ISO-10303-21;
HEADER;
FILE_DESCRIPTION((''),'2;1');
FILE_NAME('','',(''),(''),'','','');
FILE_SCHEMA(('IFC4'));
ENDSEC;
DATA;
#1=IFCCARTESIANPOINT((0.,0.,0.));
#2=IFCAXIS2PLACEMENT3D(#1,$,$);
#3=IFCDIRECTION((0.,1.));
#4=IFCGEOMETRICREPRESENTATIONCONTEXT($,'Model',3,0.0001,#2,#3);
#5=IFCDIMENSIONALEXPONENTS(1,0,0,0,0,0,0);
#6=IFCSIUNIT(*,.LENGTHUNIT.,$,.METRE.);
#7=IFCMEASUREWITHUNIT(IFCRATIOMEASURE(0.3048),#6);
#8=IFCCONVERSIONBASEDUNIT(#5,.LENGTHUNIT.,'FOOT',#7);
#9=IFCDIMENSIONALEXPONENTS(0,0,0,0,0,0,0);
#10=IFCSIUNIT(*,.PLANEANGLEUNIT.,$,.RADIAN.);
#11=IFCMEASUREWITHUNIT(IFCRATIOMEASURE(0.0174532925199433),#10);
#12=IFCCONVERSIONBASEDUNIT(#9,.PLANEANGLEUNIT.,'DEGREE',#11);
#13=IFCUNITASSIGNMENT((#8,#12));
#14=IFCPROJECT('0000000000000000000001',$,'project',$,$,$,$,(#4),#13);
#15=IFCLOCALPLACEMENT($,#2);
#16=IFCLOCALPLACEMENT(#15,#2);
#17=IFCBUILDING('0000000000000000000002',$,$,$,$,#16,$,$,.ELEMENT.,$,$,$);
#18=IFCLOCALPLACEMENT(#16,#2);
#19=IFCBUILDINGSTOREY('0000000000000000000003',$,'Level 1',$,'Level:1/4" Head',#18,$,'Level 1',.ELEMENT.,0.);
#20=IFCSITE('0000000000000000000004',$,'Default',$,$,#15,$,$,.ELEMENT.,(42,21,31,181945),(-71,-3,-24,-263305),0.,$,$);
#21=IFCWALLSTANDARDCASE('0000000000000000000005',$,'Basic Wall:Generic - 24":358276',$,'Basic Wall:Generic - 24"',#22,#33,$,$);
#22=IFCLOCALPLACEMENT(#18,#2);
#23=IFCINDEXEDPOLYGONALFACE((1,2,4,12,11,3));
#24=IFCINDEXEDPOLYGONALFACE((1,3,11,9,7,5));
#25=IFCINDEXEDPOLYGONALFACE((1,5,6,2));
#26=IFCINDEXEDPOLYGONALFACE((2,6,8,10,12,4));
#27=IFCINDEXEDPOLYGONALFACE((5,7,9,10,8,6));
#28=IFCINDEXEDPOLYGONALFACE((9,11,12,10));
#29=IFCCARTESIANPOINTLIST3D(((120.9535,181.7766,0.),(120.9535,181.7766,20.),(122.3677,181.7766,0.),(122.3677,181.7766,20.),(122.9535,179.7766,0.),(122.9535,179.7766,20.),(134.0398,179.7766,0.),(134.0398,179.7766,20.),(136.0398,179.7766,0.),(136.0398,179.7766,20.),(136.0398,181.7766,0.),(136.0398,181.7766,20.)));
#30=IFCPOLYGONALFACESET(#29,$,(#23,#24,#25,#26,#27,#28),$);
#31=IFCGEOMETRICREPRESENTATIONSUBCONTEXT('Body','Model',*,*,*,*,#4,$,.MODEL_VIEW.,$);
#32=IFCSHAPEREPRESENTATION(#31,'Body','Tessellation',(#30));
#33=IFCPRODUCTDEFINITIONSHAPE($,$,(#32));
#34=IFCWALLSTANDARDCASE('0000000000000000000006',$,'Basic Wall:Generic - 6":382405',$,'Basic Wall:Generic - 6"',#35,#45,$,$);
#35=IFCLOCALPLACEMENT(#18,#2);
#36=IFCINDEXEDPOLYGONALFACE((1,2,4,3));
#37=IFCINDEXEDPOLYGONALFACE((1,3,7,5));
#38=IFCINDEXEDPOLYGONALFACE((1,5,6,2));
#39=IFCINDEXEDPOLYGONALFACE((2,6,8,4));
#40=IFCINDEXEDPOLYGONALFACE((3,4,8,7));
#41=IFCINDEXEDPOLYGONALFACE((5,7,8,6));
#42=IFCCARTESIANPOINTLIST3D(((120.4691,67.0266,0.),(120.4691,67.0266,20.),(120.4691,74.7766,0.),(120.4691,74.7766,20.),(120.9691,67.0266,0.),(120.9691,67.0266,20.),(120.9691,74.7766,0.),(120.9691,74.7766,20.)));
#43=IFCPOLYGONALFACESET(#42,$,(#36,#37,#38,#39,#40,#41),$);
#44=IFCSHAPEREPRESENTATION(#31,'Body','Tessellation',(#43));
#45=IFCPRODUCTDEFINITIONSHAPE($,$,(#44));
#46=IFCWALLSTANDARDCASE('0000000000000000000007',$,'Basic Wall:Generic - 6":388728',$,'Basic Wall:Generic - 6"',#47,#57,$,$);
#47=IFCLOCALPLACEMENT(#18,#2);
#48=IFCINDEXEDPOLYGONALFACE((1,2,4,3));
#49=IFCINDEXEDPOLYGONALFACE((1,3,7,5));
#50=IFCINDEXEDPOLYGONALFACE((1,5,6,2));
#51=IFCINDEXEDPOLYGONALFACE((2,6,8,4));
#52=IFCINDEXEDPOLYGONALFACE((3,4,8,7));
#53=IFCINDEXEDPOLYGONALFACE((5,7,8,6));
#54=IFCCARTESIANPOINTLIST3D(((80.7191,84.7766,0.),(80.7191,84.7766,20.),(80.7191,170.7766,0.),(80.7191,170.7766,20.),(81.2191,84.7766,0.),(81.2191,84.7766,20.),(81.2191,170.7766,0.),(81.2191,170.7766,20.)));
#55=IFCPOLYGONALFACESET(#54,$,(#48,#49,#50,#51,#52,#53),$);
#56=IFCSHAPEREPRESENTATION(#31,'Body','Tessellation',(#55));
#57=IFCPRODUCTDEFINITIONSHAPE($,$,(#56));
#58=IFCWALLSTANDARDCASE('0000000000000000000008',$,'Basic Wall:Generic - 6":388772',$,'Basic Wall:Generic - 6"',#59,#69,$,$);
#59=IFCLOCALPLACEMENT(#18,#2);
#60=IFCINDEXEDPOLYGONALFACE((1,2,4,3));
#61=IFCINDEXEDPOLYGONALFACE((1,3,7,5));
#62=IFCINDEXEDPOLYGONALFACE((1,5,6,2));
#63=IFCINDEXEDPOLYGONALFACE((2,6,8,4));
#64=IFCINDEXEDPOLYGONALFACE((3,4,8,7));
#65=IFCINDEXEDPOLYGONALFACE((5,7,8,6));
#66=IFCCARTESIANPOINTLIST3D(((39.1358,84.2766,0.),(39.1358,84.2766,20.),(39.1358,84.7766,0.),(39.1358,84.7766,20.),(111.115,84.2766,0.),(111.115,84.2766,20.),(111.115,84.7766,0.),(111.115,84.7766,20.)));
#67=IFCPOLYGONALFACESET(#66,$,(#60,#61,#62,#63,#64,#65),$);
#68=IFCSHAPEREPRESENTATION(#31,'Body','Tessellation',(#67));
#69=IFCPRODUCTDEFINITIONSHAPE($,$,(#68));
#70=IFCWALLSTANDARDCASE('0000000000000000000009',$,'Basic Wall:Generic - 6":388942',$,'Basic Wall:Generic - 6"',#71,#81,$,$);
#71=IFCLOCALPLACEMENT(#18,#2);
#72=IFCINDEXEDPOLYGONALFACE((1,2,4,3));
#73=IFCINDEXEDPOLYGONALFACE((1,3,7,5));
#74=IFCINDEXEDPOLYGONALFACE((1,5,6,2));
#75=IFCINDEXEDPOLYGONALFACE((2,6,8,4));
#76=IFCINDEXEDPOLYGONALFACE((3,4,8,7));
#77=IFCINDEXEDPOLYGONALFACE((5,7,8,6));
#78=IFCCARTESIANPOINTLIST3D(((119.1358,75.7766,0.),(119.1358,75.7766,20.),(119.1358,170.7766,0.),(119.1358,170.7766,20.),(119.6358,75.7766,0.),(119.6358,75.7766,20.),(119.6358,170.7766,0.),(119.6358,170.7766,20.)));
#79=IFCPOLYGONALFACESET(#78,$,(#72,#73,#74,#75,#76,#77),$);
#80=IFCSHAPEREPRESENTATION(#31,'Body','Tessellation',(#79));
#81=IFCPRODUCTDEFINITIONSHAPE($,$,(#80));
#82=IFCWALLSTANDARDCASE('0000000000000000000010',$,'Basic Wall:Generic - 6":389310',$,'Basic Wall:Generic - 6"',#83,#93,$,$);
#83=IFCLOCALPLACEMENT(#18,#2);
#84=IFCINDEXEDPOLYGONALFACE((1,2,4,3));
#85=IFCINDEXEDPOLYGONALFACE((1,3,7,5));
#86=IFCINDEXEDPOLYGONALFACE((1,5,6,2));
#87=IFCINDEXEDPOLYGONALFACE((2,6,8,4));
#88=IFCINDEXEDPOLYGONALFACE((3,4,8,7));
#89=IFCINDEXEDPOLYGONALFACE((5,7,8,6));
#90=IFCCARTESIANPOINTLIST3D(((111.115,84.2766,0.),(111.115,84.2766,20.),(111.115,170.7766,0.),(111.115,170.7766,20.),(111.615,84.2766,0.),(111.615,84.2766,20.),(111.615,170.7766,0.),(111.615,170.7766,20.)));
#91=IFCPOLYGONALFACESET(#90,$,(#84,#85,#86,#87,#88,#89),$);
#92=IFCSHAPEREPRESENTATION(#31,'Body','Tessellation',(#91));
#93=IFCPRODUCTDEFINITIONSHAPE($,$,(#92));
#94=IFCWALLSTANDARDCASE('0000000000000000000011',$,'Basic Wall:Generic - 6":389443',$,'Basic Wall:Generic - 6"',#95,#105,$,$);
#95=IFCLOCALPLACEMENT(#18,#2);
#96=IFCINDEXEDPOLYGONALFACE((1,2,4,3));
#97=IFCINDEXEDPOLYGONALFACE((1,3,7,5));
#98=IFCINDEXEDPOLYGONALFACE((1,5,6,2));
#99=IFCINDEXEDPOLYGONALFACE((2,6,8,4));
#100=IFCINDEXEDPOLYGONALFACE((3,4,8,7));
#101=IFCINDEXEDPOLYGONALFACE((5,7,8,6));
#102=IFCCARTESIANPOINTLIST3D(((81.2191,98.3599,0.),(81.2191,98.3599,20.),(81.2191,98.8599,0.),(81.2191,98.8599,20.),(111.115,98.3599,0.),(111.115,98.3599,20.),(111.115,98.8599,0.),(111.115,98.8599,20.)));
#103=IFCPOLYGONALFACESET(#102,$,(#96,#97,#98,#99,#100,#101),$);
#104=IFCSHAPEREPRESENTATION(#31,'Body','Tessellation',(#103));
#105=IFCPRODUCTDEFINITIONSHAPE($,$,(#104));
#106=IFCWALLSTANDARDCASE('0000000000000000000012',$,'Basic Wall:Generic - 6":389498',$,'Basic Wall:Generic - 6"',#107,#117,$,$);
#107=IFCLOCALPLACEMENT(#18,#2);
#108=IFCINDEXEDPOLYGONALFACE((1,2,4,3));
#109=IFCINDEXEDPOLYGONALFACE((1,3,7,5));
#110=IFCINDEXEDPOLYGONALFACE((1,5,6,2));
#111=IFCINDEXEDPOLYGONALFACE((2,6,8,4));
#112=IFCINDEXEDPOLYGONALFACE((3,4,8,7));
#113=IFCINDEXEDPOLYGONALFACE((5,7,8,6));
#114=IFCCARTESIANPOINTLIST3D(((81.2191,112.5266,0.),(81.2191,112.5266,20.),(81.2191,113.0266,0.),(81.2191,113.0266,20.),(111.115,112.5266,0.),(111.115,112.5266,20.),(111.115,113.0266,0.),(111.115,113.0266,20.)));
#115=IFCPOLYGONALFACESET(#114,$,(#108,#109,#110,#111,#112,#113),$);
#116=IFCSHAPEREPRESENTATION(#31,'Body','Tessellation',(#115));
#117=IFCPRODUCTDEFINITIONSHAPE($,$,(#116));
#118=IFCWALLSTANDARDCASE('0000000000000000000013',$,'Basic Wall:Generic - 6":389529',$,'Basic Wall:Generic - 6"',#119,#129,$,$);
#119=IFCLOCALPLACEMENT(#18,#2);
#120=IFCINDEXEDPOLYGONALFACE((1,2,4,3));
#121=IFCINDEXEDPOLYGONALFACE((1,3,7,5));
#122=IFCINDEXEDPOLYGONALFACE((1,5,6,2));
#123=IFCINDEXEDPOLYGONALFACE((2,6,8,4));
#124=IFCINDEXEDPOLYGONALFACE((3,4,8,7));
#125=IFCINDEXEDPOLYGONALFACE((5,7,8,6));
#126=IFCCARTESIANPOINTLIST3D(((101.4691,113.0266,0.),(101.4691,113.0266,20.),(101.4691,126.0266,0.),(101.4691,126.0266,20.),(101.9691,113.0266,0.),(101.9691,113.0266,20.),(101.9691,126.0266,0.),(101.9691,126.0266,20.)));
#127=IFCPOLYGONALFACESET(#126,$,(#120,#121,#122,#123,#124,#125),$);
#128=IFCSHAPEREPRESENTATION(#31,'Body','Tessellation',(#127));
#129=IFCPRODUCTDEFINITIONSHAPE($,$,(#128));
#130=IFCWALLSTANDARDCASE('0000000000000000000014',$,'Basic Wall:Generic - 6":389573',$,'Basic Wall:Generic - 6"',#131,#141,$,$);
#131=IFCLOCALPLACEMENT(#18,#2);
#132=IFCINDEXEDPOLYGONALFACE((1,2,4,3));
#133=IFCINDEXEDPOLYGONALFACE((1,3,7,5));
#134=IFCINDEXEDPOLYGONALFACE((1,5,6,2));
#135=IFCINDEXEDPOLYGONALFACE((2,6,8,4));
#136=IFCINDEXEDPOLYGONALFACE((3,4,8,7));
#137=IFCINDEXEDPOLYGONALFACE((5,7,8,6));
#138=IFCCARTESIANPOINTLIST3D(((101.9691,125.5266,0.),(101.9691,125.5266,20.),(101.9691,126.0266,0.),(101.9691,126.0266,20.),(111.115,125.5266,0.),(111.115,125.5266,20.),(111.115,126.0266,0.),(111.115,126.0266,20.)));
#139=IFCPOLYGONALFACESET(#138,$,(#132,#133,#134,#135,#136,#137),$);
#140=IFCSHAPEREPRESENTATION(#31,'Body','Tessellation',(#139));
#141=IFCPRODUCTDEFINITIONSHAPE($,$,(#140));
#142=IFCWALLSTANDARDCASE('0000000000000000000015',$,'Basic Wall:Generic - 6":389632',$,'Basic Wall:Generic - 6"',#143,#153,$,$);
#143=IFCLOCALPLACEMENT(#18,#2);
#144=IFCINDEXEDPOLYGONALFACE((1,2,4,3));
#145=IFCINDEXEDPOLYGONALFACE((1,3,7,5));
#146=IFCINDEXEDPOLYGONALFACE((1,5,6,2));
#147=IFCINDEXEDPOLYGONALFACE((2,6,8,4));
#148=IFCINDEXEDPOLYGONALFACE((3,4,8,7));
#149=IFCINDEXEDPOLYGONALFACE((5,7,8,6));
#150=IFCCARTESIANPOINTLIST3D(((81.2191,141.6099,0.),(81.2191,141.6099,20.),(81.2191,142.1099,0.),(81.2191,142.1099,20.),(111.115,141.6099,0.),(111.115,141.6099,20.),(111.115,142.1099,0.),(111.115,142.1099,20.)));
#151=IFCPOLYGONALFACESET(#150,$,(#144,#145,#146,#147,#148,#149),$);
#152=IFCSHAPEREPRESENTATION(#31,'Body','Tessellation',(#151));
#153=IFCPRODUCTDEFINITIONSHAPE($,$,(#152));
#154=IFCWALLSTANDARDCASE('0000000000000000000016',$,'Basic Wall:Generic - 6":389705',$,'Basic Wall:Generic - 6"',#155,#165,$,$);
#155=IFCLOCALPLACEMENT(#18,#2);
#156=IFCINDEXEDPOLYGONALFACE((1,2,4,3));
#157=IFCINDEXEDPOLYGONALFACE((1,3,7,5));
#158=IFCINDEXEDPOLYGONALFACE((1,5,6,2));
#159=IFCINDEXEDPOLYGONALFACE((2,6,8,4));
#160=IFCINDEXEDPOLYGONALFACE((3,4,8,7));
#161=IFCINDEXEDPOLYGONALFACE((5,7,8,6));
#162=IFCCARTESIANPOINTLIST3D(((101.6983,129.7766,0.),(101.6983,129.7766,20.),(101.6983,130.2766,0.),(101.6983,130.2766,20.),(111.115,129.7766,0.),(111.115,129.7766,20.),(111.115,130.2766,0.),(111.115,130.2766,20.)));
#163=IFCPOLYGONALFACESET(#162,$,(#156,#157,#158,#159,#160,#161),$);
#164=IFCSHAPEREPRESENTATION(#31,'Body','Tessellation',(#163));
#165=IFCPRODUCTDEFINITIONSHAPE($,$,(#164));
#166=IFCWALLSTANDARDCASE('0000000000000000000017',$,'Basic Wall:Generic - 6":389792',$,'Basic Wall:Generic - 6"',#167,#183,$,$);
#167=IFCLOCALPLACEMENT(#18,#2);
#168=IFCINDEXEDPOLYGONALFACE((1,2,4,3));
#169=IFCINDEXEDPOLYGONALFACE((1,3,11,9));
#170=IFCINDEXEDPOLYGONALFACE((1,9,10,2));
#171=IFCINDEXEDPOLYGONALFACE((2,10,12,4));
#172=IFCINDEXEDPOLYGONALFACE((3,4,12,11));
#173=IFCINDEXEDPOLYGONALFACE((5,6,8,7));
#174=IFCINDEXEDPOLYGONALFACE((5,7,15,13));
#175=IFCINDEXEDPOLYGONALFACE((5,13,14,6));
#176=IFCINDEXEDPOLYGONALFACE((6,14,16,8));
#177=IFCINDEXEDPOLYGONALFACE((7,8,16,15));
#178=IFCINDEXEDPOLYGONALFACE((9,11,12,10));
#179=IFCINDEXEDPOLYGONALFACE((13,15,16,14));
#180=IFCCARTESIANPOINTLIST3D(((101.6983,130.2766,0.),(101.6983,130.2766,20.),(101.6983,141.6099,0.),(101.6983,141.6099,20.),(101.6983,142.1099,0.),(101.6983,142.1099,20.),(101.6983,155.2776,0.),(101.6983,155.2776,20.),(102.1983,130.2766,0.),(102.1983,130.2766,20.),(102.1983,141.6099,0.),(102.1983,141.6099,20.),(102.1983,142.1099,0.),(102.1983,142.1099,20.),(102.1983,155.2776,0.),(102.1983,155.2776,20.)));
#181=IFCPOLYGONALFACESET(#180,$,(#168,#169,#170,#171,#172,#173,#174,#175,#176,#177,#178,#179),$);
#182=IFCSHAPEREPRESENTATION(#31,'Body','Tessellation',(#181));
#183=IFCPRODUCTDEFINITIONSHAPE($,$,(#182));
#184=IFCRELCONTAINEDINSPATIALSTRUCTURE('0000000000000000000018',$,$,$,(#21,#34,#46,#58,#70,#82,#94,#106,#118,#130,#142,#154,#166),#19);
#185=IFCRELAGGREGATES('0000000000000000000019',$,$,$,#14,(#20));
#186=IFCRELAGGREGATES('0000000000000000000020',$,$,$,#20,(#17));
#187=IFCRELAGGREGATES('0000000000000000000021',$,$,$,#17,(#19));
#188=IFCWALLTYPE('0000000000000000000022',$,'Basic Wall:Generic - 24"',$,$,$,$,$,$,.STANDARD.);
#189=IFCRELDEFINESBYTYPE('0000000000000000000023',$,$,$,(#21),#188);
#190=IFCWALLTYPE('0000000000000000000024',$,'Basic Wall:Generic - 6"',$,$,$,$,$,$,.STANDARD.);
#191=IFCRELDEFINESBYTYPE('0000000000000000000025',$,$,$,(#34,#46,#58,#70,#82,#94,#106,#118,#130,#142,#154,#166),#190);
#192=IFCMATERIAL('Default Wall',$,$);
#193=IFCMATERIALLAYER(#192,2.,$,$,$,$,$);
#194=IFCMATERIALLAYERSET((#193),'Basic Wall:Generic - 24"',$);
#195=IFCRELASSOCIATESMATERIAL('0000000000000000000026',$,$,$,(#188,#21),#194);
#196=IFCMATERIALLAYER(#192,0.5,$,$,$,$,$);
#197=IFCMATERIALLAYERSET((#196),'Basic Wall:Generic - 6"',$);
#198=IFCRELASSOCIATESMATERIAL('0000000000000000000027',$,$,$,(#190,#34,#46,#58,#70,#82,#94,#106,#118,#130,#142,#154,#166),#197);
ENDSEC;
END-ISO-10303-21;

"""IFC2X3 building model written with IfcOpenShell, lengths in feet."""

from ifc_helpers import new_model, entity, si_unit, converted_unit, direction, frame, frame_2d, origin, origin_2d_with_axis, place, context, subcontext, project, spatial, polyline, rectangle, outline, extrude, material, layer, layer_set, layer_usage, type_object, element, save


model = new_model("IFC2X3")

# Units and contexts
model_context = context("Model", 3, precision=0.0001, world=origin(), true_north=direction((0.0, 1.0)))
body_context = subcontext(model_context, "Body", "Model", "MODEL_VIEW")
ifc_project = project(units=[converted_unit("LENGTHUNIT", "FOOT", entity("IfcRatioMeasure", 0.3048), si_unit("LENGTHUNIT", "METRE"), dimensions=[1, 0, 0, 0, 0, 0, 0]), converted_unit("PLANEANGLEUNIT", "DEGREE", entity("IfcRatioMeasure", 0.0174532925199433), si_unit("PLANEANGLEUNIT", "RADIAN"), dimensions=[0, 0, 0, 0, 0, 0, 0])], contexts=[model_context])

# Site, building, storey
site_placement = place(None, origin())
site = spatial("IfcSite", under=ifc_project, at=site_placement, Name="Default", CompositionType="ELEMENT", RefLatitude=(42, 21, 31, 181945), RefLongitude=(-71, -3, -24, -263305), RefElevation=0.0)
building_placement = place(site_placement, origin())
building = spatial("IfcBuilding", under=site, at=building_placement, CompositionType="ELEMENT")
storey_placement = place(building_placement, origin())
storey = spatial("IfcBuildingStorey", under=building, at=storey_placement, Name="Level 1", ObjectType="Level:1/4\" Head", LongName="Level 1", CompositionType="ELEMENT", Elevation=0.0)

# Walls
ifc_material = material(Name="Default Wall")
ifc_layer_1 = layer(ifc_material, 2.0)
ifc_layer_set_1 = layer_set([ifc_layer_1], Name="Basic Wall:Generic - 24\"")
ifc_layer_usage_1 = layer_usage(ifc_layer_set_1, "AXIS2", "NEGATIVE", 1.0)
wall_type_1 = type_object("IfcWallType", Name="Basic Wall:Generic - 24\"", PredefinedType="STANDARD", material=ifc_layer_set_1)
wall_1_placement = place(storey_placement, frame((120.9535, 180.7766, 0.0)))
element("IfcWallStandardCase", 1, at=wall_1_placement, inside=storey, type_object=wall_type_1, material=ifc_layer_usage_1, Name="Basic Wall:Generic - 24\":358276", ObjectType="Basic Wall:Generic - 24\"", context=body_context, shape_type="SweptSolid", body=[
    extrude(outline(polyline([(15.0863, -1.0), (15.0863, 1.0), (1.4142, 1.0), (0.0, 1.0), (2.0, -1.0), (13.0863, -1.0), (15.0863, -1.0)])), origin(), (0.0, 0.0, 1.0), 20.0),
])
ifc_layer_2 = layer(ifc_material, 0.5)
ifc_layer_set_2 = layer_set([ifc_layer_2], Name="Basic Wall:Generic - 6\"")
ifc_layer_usage_2 = layer_usage(ifc_layer_set_2, "AXIS2", "NEGATIVE", 0.25)
wall_type_2 = type_object("IfcWallType", Name="Basic Wall:Generic - 6\"", PredefinedType="STANDARD", material=ifc_layer_set_2)
wall_2_placement = place(storey_placement, frame((120.7191, 74.7766, 0.0), z_axis=(0.0, 0.0, 1.0), x_axis=(0.0, -1.0, 0.0)))
element("IfcWallStandardCase", 2, at=wall_2_placement, inside=storey, type_object=wall_type_2, material=ifc_layer_usage_2, Name="Basic Wall:Generic - 6\":382405", ObjectType="Basic Wall:Generic - 6\"", context=body_context, shape_type="SweptSolid", body=[
    extrude(rectangle(XDim=7.75, YDim=0.5, at=frame_2d((3.875, 0.0), x_axis=(-1.0, 0.0))), origin(), (0.0, 0.0, 1.0), 20.0),
])
ifc_layer_usage_3 = layer_usage(ifc_layer_set_2, "AXIS2", "NEGATIVE", 0.25)
wall_3_placement = place(storey_placement, frame((80.9691, 170.7766, 0.0), z_axis=(0.0, 0.0, 1.0), x_axis=(0.0, -1.0, 0.0)))
element("IfcWallStandardCase", 3, at=wall_3_placement, inside=storey, type_object=wall_type_2, material=ifc_layer_usage_3, Name="Basic Wall:Generic - 6\":388728", ObjectType="Basic Wall:Generic - 6\"", context=body_context, shape_type="SweptSolid", body=[
    extrude(rectangle(XDim=86.0, YDim=0.5, at=frame_2d((43.0, 0.0), x_axis=(-1.0, 0.0))), origin(), (0.0, 0.0, 1.0), 20.0),
])
ifc_layer_usage_4 = layer_usage(ifc_layer_set_2, "AXIS2", "NEGATIVE", 0.25)
wall_4_placement = place(storey_placement, frame((111.115, 84.5266, 0.0), z_axis=(0.0, 0.0, 1.0), x_axis=(-1.0, 0.0, 0.0)))
element("IfcWallStandardCase", 4, at=wall_4_placement, inside=storey, type_object=wall_type_2, material=ifc_layer_usage_4, Name="Basic Wall:Generic - 6\":388772", ObjectType="Basic Wall:Generic - 6\"", context=body_context, shape_type="SweptSolid", body=[
    extrude(rectangle(XDim=71.9792, YDim=0.5, at=frame_2d((35.9896, 0.0), x_axis=(-1.0, 0.0))), origin(), (0.0, 0.0, 1.0), 20.0),
])
ifc_layer_usage_5 = layer_usage(ifc_layer_set_2, "AXIS2", "NEGATIVE", 0.25)
wall_5_placement = place(storey_placement, frame((119.3858, 170.7766, 0.0), z_axis=(0.0, 0.0, 1.0), x_axis=(0.0, -1.0, 0.0)))
element("IfcWallStandardCase", 5, at=wall_5_placement, inside=storey, type_object=wall_type_2, material=ifc_layer_usage_5, Name="Basic Wall:Generic - 6\":388942", ObjectType="Basic Wall:Generic - 6\"", context=body_context, shape_type="SweptSolid", body=[
    extrude(rectangle(XDim=95.0, YDim=0.5, at=frame_2d((47.5, 0.0), x_axis=(-1.0, 0.0))), origin(), (0.0, 0.0, 1.0), 20.0),
])
ifc_layer_usage_6 = layer_usage(ifc_layer_set_2, "AXIS2", "NEGATIVE", 0.25)
wall_6_placement = place(storey_placement, frame((111.365, 170.7766, 0.0), z_axis=(0.0, 0.0, 1.0), x_axis=(0.0, -1.0, 0.0)))
element("IfcWallStandardCase", 6, at=wall_6_placement, inside=storey, type_object=wall_type_2, material=ifc_layer_usage_6, Name="Basic Wall:Generic - 6\":389310", ObjectType="Basic Wall:Generic - 6\"", context=body_context, shape_type="SweptSolid", body=[
    extrude(rectangle(XDim=86.5, YDim=0.5, at=frame_2d((43.25, 0.0), x_axis=(-1.0, 0.0))), origin(), (0.0, 0.0, 1.0), 20.0),
])
ifc_layer_usage_7 = layer_usage(ifc_layer_set_2, "AXIS2", "NEGATIVE", 0.25)
wall_7_placement = place(storey_placement, frame((81.2191, 98.6099, 0.0)))
element("IfcWallStandardCase", 7, at=wall_7_placement, inside=storey, type_object=wall_type_2, material=ifc_layer_usage_7, Name="Basic Wall:Generic - 6\":389443", ObjectType="Basic Wall:Generic - 6\"", context=body_context, shape_type="SweptSolid", body=[
    extrude(rectangle(XDim=29.8959, YDim=0.5, at=frame_2d((14.948, 0.0), x_axis=(-1.0, 0.0))), origin(), (0.0, 0.0, 1.0), 20.0),
])
ifc_layer_usage_8 = layer_usage(ifc_layer_set_2, "AXIS2", "NEGATIVE", 0.25)
wall_8_placement = place(storey_placement, frame((81.2191, 112.7766, 0.0)))
element("IfcWallStandardCase", 8, at=wall_8_placement, inside=storey, type_object=wall_type_2, material=ifc_layer_usage_8, Name="Basic Wall:Generic - 6\":389498", ObjectType="Basic Wall:Generic - 6\"", context=body_context, shape_type="SweptSolid", body=[
    extrude(rectangle(XDim=29.8959, YDim=0.5, at=frame_2d((14.948, 0.0), x_axis=(-1.0, 0.0))), origin(), (0.0, 0.0, 1.0), 20.0),
])
ifc_layer_usage_9 = layer_usage(ifc_layer_set_2, "AXIS2", "NEGATIVE", 0.25)
wall_9_placement = place(storey_placement, frame((101.7191, 113.0266, 0.0), z_axis=(0.0, 0.0, 1.0), x_axis=(0.0, 1.0, 0.0)))
element("IfcWallStandardCase", 9, at=wall_9_placement, inside=storey, type_object=wall_type_2, material=ifc_layer_usage_9, Name="Basic Wall:Generic - 6\":389529", ObjectType="Basic Wall:Generic - 6\"", context=body_context, shape_type="SweptSolid", body=[
    extrude(rectangle(XDim=13.0, YDim=0.5, at=frame_2d((6.5, 0.0), x_axis=(-1.0, 0.0))), origin(), (0.0, 0.0, 1.0), 20.0),
])
ifc_layer_usage_10 = layer_usage(ifc_layer_set_2, "AXIS2", "NEGATIVE", 0.25)
wall_10_placement = place(storey_placement, frame((101.9691, 125.7766, 0.0)))
element("IfcWallStandardCase", 10, at=wall_10_placement, inside=storey, type_object=wall_type_2, material=ifc_layer_usage_10, Name="Basic Wall:Generic - 6\":389573", ObjectType="Basic Wall:Generic - 6\"", context=body_context, shape_type="SweptSolid", body=[
    extrude(rectangle(XDim=9.1459, YDim=0.5, at=frame_2d((4.573, 0.0), x_axis=(-1.0, 0.0))), origin(), (0.0, 0.0, 1.0), 20.0),
])
ifc_layer_usage_11 = layer_usage(ifc_layer_set_2, "AXIS2", "NEGATIVE", 0.25)
wall_11_placement = place(storey_placement, frame((81.2191, 141.8599, 0.0)))
element("IfcWallStandardCase", 11, at=wall_11_placement, inside=storey, type_object=wall_type_2, material=ifc_layer_usage_11, Name="Basic Wall:Generic - 6\":389632", ObjectType="Basic Wall:Generic - 6\"", context=body_context, shape_type="SweptSolid", body=[
    extrude(rectangle(XDim=29.8959, YDim=0.5, at=frame_2d((14.948, 0.0), x_axis=(-1.0, 0.0))), origin(), (0.0, 0.0, 1.0), 20.0),
])
ifc_layer_usage_12 = layer_usage(ifc_layer_set_2, "AXIS2", "NEGATIVE", 0.25)
wall_12_placement = place(storey_placement, frame((111.115, 130.0266, 0.0), z_axis=(0.0, 0.0, 1.0), x_axis=(-1.0, 0.0, 0.0)))
element("IfcWallStandardCase", 12, at=wall_12_placement, inside=storey, type_object=wall_type_2, material=ifc_layer_usage_12, Name="Basic Wall:Generic - 6\":389705", ObjectType="Basic Wall:Generic - 6\"", context=body_context, shape_type="SweptSolid", body=[
    extrude(rectangle(XDim=9.4167, YDim=0.5, at=frame_2d((4.7084, 0.0), x_axis=(-1.0, 0.0))), origin(), (0.0, 0.0, 1.0), 20.0),
])

# Wall, opening
ifc_layer_usage_13 = layer_usage(ifc_layer_set_2, "AXIS2", "NEGATIVE", 0.25)
wall_13_placement = place(storey_placement, frame((101.9483, 130.2766, 0.0), z_axis=(0.0, 0.0, 1.0), x_axis=(0.0, 1.0, 0.0)))
wall_13 = element("IfcWallStandardCase", 13, at=wall_13_placement, inside=storey, type_object=wall_type_2, material=ifc_layer_usage_13, Name="Basic Wall:Generic - 6\":389792", ObjectType="Basic Wall:Generic - 6\"", context=body_context, shape_type="SweptSolid", body=[
    extrude(rectangle(XDim=25.0011, YDim=0.5, at=frame_2d((12.5005, 0.0), x_axis=(-1.0, 0.0))), origin(), (0.0, 0.0, 1.0), 20.0),
])
opening_placement = place(storey_placement, frame((101.9483, 130.2766, 0.0), z_axis=(0.0, 0.0, 1.0), x_axis=(0.0, 1.0, 0.0)))
element("IfcOpeningElement", 14, at=opening_placement, cuts=wall_13, ObjectType="Opening", context=body_context, shape_type="SweptSolid", body=[
    extrude(rectangle(XDim=20.0, YDim=0.5, at=origin_2d_with_axis()), frame((11.3333, 0.0, 10.0), z_axis=(1.0, 0.0, 0.0), x_axis=(0.0, 0.0, -1.0)), (0.0, 0.0, 1.0), 0.5),
])

save(model, "model.ifc")
